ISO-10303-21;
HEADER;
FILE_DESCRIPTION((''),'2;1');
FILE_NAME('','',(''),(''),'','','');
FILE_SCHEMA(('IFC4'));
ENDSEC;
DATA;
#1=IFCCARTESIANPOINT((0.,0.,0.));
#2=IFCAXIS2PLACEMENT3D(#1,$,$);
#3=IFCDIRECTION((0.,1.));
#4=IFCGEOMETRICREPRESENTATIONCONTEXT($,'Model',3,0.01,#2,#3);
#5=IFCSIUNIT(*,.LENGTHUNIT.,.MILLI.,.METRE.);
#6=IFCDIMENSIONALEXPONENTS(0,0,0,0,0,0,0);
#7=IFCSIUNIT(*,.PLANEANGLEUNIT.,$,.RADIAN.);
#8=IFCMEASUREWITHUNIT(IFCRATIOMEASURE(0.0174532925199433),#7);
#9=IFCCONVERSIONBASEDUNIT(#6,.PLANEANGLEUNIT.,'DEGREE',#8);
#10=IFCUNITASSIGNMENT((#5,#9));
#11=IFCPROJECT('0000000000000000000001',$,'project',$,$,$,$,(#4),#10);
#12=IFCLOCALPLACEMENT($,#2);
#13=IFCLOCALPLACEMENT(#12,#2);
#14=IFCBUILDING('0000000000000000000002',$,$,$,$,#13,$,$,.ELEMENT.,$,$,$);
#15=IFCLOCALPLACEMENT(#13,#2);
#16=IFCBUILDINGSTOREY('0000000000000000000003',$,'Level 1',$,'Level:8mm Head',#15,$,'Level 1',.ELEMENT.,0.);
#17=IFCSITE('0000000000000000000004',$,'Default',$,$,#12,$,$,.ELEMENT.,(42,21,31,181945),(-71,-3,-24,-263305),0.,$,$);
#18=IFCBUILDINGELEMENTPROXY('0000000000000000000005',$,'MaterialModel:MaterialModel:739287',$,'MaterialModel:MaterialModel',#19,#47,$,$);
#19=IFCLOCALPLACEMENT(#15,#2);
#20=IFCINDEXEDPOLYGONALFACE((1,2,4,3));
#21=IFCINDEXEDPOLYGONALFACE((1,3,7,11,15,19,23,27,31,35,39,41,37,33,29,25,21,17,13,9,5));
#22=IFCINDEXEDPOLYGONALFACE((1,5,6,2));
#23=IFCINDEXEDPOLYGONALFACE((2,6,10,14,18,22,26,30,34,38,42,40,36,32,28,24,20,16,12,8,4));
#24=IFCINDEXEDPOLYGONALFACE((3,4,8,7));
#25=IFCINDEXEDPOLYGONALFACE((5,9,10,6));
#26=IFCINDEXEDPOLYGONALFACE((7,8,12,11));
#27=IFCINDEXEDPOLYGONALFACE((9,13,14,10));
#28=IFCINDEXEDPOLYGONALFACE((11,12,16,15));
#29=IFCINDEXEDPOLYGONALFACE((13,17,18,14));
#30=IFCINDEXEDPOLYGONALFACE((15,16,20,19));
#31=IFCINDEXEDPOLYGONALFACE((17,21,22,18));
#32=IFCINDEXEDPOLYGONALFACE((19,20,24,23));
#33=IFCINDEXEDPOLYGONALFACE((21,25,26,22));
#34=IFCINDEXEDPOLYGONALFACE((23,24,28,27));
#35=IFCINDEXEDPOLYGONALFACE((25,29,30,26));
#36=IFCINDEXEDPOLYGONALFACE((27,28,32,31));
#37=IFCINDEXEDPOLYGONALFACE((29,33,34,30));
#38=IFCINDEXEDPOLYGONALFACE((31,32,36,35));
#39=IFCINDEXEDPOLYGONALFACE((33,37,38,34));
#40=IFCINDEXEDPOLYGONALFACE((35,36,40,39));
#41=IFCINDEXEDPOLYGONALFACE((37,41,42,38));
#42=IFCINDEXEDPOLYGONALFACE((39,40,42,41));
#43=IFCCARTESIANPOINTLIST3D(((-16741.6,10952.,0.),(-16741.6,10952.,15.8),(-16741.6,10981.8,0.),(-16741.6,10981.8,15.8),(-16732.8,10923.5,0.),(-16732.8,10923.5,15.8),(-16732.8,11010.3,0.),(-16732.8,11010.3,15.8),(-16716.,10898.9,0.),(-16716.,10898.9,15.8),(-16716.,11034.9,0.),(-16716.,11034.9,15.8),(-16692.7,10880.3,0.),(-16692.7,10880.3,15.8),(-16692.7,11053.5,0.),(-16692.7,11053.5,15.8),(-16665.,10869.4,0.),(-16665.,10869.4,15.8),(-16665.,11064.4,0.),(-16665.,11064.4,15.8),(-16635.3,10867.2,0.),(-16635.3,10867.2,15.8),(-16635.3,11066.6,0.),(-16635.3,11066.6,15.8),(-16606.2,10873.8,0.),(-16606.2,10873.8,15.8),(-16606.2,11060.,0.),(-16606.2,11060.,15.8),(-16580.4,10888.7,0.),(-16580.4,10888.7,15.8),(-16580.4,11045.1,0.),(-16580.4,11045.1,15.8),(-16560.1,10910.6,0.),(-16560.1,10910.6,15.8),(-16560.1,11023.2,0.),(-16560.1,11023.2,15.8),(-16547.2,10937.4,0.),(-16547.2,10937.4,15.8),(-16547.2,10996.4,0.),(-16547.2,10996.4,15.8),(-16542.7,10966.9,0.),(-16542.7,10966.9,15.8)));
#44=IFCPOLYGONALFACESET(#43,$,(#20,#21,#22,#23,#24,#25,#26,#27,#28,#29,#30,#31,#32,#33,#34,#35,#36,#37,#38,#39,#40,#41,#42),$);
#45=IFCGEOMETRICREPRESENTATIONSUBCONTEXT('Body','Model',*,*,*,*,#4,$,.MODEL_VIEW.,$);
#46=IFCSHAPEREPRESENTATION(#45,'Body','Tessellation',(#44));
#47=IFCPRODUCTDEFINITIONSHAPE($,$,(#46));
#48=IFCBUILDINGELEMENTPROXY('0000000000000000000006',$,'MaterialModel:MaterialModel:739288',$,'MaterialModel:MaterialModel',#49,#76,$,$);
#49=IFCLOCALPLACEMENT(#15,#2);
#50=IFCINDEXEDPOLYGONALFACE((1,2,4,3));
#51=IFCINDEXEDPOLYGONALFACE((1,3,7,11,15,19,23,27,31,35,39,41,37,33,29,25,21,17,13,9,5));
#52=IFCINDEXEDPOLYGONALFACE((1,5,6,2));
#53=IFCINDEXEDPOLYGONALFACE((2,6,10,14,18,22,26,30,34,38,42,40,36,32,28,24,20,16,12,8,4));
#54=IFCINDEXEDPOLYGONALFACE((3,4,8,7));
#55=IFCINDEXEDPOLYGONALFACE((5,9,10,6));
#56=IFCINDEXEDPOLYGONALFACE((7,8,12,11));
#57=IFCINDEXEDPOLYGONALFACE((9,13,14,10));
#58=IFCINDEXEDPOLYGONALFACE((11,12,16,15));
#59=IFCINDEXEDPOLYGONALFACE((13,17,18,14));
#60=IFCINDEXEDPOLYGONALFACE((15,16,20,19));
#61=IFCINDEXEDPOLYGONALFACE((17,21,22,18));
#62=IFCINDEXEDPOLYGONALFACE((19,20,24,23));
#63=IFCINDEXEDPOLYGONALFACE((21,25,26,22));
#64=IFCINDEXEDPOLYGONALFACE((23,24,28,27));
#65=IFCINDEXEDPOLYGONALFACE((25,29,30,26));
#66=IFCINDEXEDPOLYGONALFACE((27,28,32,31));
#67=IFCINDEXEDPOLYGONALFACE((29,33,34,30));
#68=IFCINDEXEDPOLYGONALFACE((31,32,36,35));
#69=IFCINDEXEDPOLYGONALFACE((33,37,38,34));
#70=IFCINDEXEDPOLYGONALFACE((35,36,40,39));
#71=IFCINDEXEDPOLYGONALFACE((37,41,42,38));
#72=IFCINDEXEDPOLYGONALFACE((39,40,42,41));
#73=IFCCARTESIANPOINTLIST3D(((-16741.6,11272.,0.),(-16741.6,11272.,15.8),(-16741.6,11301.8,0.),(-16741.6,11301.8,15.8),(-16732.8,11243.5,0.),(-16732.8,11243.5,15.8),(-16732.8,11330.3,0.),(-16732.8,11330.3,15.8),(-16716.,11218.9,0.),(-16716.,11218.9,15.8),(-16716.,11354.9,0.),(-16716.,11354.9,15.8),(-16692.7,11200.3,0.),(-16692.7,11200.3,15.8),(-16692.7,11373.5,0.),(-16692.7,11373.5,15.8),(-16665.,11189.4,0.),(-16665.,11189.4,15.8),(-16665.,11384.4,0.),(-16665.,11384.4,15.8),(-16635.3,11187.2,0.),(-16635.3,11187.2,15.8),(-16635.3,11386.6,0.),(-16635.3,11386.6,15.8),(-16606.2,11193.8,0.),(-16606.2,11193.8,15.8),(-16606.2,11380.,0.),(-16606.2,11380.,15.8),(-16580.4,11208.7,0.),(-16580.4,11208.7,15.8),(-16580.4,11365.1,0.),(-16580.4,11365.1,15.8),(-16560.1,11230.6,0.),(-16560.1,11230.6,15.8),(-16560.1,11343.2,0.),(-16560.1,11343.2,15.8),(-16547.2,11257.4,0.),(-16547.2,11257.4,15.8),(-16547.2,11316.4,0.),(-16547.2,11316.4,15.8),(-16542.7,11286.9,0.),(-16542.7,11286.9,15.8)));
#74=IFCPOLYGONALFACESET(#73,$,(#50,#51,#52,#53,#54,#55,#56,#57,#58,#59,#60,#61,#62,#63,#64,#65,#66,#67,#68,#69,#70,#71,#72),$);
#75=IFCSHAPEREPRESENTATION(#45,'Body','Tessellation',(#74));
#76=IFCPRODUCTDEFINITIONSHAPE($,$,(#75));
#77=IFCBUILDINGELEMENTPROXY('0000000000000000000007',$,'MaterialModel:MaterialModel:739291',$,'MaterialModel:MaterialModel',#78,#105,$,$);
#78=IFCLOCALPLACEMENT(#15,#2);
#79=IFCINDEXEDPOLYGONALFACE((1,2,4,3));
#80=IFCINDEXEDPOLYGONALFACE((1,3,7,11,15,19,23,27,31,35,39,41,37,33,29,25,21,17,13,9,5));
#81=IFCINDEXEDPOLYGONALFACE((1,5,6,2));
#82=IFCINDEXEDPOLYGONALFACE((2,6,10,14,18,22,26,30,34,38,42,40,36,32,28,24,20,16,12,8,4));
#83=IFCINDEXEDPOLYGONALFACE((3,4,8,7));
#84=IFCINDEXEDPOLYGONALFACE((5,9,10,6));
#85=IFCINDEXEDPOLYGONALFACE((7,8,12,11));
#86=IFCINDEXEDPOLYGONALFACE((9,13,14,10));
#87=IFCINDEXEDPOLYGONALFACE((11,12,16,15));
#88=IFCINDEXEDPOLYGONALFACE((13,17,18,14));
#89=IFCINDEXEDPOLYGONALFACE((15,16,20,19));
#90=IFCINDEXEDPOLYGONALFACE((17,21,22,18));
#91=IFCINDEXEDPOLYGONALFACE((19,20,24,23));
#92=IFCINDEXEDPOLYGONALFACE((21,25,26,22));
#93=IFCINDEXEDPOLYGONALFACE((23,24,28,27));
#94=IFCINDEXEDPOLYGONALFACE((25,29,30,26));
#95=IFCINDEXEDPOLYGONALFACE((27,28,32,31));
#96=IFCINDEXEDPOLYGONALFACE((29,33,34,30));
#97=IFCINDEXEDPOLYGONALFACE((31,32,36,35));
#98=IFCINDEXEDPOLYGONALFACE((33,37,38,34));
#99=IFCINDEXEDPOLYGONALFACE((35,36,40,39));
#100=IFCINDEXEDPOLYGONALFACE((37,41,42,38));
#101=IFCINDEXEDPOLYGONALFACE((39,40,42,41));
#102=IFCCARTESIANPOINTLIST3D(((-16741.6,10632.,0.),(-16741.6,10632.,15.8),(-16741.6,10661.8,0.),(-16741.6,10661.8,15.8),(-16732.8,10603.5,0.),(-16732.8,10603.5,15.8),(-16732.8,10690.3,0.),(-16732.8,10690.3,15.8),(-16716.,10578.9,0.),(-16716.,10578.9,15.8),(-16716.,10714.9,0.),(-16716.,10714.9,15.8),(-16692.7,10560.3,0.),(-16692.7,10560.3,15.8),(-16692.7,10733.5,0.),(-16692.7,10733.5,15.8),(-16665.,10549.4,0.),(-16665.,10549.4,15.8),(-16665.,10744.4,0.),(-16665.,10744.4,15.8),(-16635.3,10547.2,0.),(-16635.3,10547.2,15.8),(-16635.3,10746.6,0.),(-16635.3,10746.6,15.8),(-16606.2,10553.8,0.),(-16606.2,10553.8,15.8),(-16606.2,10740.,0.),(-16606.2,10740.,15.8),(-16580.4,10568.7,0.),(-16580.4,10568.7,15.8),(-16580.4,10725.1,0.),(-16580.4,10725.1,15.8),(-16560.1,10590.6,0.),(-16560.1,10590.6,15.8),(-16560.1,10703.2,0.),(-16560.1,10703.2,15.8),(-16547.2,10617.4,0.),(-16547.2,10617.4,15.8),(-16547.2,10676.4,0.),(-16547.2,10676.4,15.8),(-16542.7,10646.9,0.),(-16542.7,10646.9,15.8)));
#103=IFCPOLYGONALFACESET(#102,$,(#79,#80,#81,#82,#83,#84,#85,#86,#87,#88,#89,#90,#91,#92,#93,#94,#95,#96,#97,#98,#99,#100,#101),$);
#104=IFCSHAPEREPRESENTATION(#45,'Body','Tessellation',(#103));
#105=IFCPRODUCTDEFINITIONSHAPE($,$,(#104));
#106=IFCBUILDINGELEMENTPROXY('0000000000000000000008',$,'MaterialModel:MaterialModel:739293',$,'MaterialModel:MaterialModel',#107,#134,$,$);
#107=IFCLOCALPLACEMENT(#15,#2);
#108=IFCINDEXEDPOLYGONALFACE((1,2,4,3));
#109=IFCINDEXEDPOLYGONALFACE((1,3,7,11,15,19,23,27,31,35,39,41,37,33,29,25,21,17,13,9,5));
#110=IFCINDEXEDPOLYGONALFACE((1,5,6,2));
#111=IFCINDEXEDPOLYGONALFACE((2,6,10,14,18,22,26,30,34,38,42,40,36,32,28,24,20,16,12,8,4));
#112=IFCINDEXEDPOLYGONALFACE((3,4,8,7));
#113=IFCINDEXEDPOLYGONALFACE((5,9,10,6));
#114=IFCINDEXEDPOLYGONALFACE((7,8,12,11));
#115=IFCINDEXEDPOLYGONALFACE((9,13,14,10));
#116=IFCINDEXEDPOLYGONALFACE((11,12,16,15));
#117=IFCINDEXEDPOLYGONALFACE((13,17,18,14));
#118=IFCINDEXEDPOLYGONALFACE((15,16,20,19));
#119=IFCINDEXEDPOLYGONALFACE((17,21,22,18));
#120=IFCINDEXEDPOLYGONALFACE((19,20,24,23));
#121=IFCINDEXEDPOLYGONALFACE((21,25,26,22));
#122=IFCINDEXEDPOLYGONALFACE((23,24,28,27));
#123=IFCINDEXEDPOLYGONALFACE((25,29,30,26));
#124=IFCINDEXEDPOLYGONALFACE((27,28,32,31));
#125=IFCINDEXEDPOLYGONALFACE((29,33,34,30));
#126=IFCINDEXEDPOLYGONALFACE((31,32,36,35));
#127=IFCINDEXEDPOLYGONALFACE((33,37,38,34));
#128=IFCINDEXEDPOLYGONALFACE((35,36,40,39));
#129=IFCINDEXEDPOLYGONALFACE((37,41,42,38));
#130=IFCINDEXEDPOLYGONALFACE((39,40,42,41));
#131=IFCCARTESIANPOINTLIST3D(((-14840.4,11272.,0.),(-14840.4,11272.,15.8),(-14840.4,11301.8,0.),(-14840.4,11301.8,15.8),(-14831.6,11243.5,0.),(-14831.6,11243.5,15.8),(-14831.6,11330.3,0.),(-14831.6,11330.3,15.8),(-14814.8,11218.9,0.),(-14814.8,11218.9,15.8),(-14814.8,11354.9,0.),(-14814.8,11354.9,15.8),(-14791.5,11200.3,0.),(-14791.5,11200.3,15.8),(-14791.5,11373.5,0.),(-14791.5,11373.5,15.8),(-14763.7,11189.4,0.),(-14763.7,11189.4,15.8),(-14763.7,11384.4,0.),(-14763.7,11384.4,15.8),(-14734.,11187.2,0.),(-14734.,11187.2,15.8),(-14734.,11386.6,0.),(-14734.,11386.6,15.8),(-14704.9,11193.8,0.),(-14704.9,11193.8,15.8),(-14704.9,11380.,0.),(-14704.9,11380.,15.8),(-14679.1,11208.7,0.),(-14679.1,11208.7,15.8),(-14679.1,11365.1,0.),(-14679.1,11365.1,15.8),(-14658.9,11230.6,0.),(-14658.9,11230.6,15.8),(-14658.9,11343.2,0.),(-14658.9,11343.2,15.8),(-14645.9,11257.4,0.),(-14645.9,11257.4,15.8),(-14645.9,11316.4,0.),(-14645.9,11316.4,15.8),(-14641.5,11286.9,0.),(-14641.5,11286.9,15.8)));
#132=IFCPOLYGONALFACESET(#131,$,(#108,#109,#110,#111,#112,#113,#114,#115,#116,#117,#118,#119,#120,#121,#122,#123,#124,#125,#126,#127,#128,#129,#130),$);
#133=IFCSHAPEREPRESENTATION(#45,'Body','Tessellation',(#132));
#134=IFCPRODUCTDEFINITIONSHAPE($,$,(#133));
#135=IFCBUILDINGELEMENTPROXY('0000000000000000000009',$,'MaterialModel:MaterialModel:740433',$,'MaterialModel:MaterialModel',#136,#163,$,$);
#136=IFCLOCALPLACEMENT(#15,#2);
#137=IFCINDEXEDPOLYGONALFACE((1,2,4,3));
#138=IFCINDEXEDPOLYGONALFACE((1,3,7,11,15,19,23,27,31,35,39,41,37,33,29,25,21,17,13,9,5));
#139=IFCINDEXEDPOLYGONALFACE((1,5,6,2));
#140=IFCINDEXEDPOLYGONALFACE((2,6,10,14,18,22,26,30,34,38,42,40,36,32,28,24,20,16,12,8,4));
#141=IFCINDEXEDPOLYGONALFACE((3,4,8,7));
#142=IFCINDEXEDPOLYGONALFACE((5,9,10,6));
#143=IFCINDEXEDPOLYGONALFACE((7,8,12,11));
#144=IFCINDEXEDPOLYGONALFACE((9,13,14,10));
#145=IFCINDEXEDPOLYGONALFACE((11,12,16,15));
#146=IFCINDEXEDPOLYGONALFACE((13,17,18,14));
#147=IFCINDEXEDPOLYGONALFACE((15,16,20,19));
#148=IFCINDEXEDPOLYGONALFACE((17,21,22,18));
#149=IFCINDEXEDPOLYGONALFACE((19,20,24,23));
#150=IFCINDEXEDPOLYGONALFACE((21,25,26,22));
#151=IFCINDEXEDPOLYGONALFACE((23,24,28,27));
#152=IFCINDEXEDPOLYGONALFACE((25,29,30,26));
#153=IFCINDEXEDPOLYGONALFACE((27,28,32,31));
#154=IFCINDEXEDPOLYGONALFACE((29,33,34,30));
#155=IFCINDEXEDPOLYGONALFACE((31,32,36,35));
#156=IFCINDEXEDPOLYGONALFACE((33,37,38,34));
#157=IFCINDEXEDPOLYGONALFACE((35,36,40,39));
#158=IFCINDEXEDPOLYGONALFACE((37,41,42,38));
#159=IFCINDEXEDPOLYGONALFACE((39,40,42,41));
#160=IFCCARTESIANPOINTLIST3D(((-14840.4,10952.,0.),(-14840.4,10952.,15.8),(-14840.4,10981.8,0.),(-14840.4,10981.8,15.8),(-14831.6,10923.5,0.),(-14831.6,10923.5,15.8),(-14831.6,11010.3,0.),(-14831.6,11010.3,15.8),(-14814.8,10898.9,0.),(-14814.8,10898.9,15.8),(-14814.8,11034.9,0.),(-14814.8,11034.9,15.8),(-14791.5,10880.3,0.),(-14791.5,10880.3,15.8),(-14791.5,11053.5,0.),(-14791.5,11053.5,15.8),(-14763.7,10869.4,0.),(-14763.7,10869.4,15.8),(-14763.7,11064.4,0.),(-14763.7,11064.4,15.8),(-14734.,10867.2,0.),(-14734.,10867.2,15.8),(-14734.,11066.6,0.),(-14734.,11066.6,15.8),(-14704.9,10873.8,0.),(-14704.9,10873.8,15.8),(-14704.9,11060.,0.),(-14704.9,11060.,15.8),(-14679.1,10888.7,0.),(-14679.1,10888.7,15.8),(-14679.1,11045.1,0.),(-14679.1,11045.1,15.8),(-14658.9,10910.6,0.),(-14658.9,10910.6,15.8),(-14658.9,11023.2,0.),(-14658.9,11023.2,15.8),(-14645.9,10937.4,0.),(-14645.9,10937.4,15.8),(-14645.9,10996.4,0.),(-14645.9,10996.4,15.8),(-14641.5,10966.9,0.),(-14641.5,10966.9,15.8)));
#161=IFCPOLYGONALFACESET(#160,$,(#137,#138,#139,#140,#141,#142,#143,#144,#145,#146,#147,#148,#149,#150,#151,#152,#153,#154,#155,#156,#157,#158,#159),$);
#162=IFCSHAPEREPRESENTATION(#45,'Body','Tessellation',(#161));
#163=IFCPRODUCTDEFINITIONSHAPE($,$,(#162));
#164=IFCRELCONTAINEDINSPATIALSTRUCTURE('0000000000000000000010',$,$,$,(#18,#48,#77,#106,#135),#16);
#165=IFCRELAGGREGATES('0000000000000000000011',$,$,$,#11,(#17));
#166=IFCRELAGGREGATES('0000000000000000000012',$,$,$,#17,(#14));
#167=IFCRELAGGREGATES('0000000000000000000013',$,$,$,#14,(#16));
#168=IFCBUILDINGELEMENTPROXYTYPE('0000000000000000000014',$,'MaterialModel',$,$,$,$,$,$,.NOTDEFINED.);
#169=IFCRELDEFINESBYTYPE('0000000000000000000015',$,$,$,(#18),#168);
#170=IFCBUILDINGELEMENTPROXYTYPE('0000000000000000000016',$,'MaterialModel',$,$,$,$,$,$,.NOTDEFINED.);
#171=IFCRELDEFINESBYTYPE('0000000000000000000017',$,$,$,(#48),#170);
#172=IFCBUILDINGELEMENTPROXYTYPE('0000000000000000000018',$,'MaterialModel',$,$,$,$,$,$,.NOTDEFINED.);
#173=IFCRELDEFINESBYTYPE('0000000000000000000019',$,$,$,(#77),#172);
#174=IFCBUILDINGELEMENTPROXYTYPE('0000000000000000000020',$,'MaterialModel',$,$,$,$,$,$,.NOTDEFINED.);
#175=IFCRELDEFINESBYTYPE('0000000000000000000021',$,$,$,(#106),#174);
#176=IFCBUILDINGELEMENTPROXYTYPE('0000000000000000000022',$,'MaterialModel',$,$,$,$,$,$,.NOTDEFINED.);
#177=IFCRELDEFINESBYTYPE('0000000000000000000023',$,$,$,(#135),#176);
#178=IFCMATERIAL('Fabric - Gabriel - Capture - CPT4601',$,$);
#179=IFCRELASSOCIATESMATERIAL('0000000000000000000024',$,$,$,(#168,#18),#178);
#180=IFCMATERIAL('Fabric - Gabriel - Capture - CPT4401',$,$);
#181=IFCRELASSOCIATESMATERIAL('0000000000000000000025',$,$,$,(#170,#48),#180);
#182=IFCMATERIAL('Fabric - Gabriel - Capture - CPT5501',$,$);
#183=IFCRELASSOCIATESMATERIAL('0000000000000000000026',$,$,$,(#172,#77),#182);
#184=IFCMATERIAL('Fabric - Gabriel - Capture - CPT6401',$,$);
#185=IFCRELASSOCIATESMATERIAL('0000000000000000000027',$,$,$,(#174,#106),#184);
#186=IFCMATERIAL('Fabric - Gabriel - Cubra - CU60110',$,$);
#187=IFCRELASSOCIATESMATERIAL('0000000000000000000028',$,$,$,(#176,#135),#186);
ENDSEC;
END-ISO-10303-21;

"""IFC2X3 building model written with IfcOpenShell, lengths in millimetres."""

from ifc_helpers import new_model, entity, si_unit, converted_unit, direction, frame, frame_2d, origin, place, context, subcontext, project, spatial, circle, extrude, source, transform, mapped, material, type_object, type_shapes, element, save


model = new_model("IFC2X3")

# Units and contexts
model_context = context("Model", 3, precision=0.01, world=origin(), true_north=direction((0.0, 1.0)))
body_context = subcontext(model_context, "Body", "Model", "MODEL_VIEW")
ifc_project = project(units=[si_unit("LENGTHUNIT", "METRE", prefix="MILLI"), converted_unit("PLANEANGLEUNIT", "DEGREE", entity("IfcRatioMeasure", 0.0174532925199433), si_unit("PLANEANGLEUNIT", "RADIAN"), dimensions=[0, 0, 0, 0, 0, 0, 0])], contexts=[model_context])

# Site, building, storey
site_placement = place(None, origin())
site = spatial("IfcSite", under=ifc_project, at=site_placement, Name="Default", CompositionType="ELEMENT", RefLatitude=(42, 21, 31, 181945), RefLongitude=(-71, -3, -24, -263305), RefElevation=0.0)
building_placement = place(site_placement, origin())
building = spatial("IfcBuilding", under=site, at=building_placement, CompositionType="ELEMENT")
storey_placement = place(building_placement, origin())
storey = spatial("IfcBuildingStorey", under=building, at=storey_placement, Name="Level 1", ObjectType="Level:8mm Head", LongName="Level 1", CompositionType="ELEMENT", Elevation=0.0)

# Building element proxies
ifc_material_1 = material(Name="Fabric - Gabriel - Capture - CPT4601")
building_element_proxy_type_1 = type_object("IfcBuildingElementProxyType", Name="MaterialModel", PredefinedType="NOTDEFINED", material=ifc_material_1)
shared_shape_1 = source(origin(), body_context, "Body", "SweptSolid", [
    extrude(circle(Radius=100.0, at=frame_2d((0.0, 0.0), x_axis=(1.0, 0.0))), origin(), (0.0, 0.0, 1.0), 15.8),
])
type_shapes(building_element_proxy_type_1, [shared_shape_1])
proxy_1_placement = place(storey_placement, frame((-16642.7, 10966.9, 0.0)))
element("IfcBuildingElementProxy", 1, at=proxy_1_placement, inside=storey, type_object=building_element_proxy_type_1, material=ifc_material_1, Name="MaterialModel:MaterialModel:739287", ObjectType="MaterialModel:MaterialModel", context=body_context, shape_type="MappedRepresentation", body=[
    mapped(shared_shape_1, transform((0.0, 0.0, 0.0), scale=1.0)),
])
ifc_material_2 = material(Name="Fabric - Gabriel - Capture - CPT4401")
building_element_proxy_type_2 = type_object("IfcBuildingElementProxyType", Name="MaterialModel", PredefinedType="NOTDEFINED", material=ifc_material_2)
shared_shape_2 = source(origin(), body_context, "Body", "SweptSolid", [
    extrude(circle(Radius=100.0, at=frame_2d((0.0, 0.0), x_axis=(1.0, 0.0))), origin(), (0.0, 0.0, 1.0), 15.8),
])
type_shapes(building_element_proxy_type_2, [shared_shape_2])
proxy_2_placement = place(storey_placement, frame((-16642.7, 11286.9, 0.0)))
element("IfcBuildingElementProxy", 2, at=proxy_2_placement, inside=storey, type_object=building_element_proxy_type_2, material=ifc_material_2, Name="MaterialModel:MaterialModel:739288", ObjectType="MaterialModel:MaterialModel", context=body_context, shape_type="MappedRepresentation", body=[
    mapped(shared_shape_2, transform((0.0, 0.0, 0.0), scale=1.0)),
])
ifc_material_3 = material(Name="Fabric - Gabriel - Capture - CPT5501")
building_element_proxy_type_3 = type_object("IfcBuildingElementProxyType", Name="MaterialModel", PredefinedType="NOTDEFINED", material=ifc_material_3)
shared_shape_3 = source(origin(), body_context, "Body", "SweptSolid", [
    extrude(circle(Radius=100.0, at=frame_2d((0.0, 0.0), x_axis=(1.0, 0.0))), origin(), (0.0, 0.0, 1.0), 15.8),
])
type_shapes(building_element_proxy_type_3, [shared_shape_3])
proxy_3_placement = place(storey_placement, frame((-16642.7, 10646.9, 0.0)))
element("IfcBuildingElementProxy", 3, at=proxy_3_placement, inside=storey, type_object=building_element_proxy_type_3, material=ifc_material_3, Name="MaterialModel:MaterialModel:739291", ObjectType="MaterialModel:MaterialModel", context=body_context, shape_type="MappedRepresentation", body=[
    mapped(shared_shape_3, transform((0.0, 0.0, 0.0), scale=1.0)),
])
ifc_material_4 = material(Name="Fabric - Gabriel - Capture - CPT6401")
building_element_proxy_type_4 = type_object("IfcBuildingElementProxyType", Name="MaterialModel", PredefinedType="NOTDEFINED", material=ifc_material_4)
shared_shape_4 = source(origin(), body_context, "Body", "SweptSolid", [
    extrude(circle(Radius=100.0, at=frame_2d((0.0, 0.0), x_axis=(1.0, 0.0))), origin(), (0.0, 0.0, 1.0), 15.8),
])
type_shapes(building_element_proxy_type_4, [shared_shape_4])
proxy_4_placement = place(storey_placement, frame((-14741.5, 11286.9, 0.0)))
element("IfcBuildingElementProxy", 4, at=proxy_4_placement, inside=storey, type_object=building_element_proxy_type_4, material=ifc_material_4, Name="MaterialModel:MaterialModel:739293", ObjectType="MaterialModel:MaterialModel", context=body_context, shape_type="MappedRepresentation", body=[
    mapped(shared_shape_4, transform((0.0, 0.0, 0.0), scale=1.0)),
])
ifc_material_5 = material(Name="Fabric - Gabriel - Cubra - CU60110")
building_element_proxy_type_5 = type_object("IfcBuildingElementProxyType", Name="MaterialModel", PredefinedType="NOTDEFINED", material=ifc_material_5)
shared_shape_5 = source(origin(), body_context, "Body", "SweptSolid", [
    extrude(circle(Radius=100.0, at=frame_2d((0.0, 0.0), x_axis=(1.0, 0.0))), origin(), (0.0, 0.0, 1.0), 15.8),
])
type_shapes(building_element_proxy_type_5, [shared_shape_5])
proxy_5_placement = place(storey_placement, frame((-14741.5, 10966.9, 0.0)))
element("IfcBuildingElementProxy", 5, at=proxy_5_placement, inside=storey, type_object=building_element_proxy_type_5, material=ifc_material_5, Name="MaterialModel:MaterialModel:740433", ObjectType="MaterialModel:MaterialModel", context=body_context, shape_type="MappedRepresentation", body=[
    mapped(shared_shape_5, transform((0.0, 0.0, 0.0), scale=1.0)),
])

save(model, "model.ifc")
